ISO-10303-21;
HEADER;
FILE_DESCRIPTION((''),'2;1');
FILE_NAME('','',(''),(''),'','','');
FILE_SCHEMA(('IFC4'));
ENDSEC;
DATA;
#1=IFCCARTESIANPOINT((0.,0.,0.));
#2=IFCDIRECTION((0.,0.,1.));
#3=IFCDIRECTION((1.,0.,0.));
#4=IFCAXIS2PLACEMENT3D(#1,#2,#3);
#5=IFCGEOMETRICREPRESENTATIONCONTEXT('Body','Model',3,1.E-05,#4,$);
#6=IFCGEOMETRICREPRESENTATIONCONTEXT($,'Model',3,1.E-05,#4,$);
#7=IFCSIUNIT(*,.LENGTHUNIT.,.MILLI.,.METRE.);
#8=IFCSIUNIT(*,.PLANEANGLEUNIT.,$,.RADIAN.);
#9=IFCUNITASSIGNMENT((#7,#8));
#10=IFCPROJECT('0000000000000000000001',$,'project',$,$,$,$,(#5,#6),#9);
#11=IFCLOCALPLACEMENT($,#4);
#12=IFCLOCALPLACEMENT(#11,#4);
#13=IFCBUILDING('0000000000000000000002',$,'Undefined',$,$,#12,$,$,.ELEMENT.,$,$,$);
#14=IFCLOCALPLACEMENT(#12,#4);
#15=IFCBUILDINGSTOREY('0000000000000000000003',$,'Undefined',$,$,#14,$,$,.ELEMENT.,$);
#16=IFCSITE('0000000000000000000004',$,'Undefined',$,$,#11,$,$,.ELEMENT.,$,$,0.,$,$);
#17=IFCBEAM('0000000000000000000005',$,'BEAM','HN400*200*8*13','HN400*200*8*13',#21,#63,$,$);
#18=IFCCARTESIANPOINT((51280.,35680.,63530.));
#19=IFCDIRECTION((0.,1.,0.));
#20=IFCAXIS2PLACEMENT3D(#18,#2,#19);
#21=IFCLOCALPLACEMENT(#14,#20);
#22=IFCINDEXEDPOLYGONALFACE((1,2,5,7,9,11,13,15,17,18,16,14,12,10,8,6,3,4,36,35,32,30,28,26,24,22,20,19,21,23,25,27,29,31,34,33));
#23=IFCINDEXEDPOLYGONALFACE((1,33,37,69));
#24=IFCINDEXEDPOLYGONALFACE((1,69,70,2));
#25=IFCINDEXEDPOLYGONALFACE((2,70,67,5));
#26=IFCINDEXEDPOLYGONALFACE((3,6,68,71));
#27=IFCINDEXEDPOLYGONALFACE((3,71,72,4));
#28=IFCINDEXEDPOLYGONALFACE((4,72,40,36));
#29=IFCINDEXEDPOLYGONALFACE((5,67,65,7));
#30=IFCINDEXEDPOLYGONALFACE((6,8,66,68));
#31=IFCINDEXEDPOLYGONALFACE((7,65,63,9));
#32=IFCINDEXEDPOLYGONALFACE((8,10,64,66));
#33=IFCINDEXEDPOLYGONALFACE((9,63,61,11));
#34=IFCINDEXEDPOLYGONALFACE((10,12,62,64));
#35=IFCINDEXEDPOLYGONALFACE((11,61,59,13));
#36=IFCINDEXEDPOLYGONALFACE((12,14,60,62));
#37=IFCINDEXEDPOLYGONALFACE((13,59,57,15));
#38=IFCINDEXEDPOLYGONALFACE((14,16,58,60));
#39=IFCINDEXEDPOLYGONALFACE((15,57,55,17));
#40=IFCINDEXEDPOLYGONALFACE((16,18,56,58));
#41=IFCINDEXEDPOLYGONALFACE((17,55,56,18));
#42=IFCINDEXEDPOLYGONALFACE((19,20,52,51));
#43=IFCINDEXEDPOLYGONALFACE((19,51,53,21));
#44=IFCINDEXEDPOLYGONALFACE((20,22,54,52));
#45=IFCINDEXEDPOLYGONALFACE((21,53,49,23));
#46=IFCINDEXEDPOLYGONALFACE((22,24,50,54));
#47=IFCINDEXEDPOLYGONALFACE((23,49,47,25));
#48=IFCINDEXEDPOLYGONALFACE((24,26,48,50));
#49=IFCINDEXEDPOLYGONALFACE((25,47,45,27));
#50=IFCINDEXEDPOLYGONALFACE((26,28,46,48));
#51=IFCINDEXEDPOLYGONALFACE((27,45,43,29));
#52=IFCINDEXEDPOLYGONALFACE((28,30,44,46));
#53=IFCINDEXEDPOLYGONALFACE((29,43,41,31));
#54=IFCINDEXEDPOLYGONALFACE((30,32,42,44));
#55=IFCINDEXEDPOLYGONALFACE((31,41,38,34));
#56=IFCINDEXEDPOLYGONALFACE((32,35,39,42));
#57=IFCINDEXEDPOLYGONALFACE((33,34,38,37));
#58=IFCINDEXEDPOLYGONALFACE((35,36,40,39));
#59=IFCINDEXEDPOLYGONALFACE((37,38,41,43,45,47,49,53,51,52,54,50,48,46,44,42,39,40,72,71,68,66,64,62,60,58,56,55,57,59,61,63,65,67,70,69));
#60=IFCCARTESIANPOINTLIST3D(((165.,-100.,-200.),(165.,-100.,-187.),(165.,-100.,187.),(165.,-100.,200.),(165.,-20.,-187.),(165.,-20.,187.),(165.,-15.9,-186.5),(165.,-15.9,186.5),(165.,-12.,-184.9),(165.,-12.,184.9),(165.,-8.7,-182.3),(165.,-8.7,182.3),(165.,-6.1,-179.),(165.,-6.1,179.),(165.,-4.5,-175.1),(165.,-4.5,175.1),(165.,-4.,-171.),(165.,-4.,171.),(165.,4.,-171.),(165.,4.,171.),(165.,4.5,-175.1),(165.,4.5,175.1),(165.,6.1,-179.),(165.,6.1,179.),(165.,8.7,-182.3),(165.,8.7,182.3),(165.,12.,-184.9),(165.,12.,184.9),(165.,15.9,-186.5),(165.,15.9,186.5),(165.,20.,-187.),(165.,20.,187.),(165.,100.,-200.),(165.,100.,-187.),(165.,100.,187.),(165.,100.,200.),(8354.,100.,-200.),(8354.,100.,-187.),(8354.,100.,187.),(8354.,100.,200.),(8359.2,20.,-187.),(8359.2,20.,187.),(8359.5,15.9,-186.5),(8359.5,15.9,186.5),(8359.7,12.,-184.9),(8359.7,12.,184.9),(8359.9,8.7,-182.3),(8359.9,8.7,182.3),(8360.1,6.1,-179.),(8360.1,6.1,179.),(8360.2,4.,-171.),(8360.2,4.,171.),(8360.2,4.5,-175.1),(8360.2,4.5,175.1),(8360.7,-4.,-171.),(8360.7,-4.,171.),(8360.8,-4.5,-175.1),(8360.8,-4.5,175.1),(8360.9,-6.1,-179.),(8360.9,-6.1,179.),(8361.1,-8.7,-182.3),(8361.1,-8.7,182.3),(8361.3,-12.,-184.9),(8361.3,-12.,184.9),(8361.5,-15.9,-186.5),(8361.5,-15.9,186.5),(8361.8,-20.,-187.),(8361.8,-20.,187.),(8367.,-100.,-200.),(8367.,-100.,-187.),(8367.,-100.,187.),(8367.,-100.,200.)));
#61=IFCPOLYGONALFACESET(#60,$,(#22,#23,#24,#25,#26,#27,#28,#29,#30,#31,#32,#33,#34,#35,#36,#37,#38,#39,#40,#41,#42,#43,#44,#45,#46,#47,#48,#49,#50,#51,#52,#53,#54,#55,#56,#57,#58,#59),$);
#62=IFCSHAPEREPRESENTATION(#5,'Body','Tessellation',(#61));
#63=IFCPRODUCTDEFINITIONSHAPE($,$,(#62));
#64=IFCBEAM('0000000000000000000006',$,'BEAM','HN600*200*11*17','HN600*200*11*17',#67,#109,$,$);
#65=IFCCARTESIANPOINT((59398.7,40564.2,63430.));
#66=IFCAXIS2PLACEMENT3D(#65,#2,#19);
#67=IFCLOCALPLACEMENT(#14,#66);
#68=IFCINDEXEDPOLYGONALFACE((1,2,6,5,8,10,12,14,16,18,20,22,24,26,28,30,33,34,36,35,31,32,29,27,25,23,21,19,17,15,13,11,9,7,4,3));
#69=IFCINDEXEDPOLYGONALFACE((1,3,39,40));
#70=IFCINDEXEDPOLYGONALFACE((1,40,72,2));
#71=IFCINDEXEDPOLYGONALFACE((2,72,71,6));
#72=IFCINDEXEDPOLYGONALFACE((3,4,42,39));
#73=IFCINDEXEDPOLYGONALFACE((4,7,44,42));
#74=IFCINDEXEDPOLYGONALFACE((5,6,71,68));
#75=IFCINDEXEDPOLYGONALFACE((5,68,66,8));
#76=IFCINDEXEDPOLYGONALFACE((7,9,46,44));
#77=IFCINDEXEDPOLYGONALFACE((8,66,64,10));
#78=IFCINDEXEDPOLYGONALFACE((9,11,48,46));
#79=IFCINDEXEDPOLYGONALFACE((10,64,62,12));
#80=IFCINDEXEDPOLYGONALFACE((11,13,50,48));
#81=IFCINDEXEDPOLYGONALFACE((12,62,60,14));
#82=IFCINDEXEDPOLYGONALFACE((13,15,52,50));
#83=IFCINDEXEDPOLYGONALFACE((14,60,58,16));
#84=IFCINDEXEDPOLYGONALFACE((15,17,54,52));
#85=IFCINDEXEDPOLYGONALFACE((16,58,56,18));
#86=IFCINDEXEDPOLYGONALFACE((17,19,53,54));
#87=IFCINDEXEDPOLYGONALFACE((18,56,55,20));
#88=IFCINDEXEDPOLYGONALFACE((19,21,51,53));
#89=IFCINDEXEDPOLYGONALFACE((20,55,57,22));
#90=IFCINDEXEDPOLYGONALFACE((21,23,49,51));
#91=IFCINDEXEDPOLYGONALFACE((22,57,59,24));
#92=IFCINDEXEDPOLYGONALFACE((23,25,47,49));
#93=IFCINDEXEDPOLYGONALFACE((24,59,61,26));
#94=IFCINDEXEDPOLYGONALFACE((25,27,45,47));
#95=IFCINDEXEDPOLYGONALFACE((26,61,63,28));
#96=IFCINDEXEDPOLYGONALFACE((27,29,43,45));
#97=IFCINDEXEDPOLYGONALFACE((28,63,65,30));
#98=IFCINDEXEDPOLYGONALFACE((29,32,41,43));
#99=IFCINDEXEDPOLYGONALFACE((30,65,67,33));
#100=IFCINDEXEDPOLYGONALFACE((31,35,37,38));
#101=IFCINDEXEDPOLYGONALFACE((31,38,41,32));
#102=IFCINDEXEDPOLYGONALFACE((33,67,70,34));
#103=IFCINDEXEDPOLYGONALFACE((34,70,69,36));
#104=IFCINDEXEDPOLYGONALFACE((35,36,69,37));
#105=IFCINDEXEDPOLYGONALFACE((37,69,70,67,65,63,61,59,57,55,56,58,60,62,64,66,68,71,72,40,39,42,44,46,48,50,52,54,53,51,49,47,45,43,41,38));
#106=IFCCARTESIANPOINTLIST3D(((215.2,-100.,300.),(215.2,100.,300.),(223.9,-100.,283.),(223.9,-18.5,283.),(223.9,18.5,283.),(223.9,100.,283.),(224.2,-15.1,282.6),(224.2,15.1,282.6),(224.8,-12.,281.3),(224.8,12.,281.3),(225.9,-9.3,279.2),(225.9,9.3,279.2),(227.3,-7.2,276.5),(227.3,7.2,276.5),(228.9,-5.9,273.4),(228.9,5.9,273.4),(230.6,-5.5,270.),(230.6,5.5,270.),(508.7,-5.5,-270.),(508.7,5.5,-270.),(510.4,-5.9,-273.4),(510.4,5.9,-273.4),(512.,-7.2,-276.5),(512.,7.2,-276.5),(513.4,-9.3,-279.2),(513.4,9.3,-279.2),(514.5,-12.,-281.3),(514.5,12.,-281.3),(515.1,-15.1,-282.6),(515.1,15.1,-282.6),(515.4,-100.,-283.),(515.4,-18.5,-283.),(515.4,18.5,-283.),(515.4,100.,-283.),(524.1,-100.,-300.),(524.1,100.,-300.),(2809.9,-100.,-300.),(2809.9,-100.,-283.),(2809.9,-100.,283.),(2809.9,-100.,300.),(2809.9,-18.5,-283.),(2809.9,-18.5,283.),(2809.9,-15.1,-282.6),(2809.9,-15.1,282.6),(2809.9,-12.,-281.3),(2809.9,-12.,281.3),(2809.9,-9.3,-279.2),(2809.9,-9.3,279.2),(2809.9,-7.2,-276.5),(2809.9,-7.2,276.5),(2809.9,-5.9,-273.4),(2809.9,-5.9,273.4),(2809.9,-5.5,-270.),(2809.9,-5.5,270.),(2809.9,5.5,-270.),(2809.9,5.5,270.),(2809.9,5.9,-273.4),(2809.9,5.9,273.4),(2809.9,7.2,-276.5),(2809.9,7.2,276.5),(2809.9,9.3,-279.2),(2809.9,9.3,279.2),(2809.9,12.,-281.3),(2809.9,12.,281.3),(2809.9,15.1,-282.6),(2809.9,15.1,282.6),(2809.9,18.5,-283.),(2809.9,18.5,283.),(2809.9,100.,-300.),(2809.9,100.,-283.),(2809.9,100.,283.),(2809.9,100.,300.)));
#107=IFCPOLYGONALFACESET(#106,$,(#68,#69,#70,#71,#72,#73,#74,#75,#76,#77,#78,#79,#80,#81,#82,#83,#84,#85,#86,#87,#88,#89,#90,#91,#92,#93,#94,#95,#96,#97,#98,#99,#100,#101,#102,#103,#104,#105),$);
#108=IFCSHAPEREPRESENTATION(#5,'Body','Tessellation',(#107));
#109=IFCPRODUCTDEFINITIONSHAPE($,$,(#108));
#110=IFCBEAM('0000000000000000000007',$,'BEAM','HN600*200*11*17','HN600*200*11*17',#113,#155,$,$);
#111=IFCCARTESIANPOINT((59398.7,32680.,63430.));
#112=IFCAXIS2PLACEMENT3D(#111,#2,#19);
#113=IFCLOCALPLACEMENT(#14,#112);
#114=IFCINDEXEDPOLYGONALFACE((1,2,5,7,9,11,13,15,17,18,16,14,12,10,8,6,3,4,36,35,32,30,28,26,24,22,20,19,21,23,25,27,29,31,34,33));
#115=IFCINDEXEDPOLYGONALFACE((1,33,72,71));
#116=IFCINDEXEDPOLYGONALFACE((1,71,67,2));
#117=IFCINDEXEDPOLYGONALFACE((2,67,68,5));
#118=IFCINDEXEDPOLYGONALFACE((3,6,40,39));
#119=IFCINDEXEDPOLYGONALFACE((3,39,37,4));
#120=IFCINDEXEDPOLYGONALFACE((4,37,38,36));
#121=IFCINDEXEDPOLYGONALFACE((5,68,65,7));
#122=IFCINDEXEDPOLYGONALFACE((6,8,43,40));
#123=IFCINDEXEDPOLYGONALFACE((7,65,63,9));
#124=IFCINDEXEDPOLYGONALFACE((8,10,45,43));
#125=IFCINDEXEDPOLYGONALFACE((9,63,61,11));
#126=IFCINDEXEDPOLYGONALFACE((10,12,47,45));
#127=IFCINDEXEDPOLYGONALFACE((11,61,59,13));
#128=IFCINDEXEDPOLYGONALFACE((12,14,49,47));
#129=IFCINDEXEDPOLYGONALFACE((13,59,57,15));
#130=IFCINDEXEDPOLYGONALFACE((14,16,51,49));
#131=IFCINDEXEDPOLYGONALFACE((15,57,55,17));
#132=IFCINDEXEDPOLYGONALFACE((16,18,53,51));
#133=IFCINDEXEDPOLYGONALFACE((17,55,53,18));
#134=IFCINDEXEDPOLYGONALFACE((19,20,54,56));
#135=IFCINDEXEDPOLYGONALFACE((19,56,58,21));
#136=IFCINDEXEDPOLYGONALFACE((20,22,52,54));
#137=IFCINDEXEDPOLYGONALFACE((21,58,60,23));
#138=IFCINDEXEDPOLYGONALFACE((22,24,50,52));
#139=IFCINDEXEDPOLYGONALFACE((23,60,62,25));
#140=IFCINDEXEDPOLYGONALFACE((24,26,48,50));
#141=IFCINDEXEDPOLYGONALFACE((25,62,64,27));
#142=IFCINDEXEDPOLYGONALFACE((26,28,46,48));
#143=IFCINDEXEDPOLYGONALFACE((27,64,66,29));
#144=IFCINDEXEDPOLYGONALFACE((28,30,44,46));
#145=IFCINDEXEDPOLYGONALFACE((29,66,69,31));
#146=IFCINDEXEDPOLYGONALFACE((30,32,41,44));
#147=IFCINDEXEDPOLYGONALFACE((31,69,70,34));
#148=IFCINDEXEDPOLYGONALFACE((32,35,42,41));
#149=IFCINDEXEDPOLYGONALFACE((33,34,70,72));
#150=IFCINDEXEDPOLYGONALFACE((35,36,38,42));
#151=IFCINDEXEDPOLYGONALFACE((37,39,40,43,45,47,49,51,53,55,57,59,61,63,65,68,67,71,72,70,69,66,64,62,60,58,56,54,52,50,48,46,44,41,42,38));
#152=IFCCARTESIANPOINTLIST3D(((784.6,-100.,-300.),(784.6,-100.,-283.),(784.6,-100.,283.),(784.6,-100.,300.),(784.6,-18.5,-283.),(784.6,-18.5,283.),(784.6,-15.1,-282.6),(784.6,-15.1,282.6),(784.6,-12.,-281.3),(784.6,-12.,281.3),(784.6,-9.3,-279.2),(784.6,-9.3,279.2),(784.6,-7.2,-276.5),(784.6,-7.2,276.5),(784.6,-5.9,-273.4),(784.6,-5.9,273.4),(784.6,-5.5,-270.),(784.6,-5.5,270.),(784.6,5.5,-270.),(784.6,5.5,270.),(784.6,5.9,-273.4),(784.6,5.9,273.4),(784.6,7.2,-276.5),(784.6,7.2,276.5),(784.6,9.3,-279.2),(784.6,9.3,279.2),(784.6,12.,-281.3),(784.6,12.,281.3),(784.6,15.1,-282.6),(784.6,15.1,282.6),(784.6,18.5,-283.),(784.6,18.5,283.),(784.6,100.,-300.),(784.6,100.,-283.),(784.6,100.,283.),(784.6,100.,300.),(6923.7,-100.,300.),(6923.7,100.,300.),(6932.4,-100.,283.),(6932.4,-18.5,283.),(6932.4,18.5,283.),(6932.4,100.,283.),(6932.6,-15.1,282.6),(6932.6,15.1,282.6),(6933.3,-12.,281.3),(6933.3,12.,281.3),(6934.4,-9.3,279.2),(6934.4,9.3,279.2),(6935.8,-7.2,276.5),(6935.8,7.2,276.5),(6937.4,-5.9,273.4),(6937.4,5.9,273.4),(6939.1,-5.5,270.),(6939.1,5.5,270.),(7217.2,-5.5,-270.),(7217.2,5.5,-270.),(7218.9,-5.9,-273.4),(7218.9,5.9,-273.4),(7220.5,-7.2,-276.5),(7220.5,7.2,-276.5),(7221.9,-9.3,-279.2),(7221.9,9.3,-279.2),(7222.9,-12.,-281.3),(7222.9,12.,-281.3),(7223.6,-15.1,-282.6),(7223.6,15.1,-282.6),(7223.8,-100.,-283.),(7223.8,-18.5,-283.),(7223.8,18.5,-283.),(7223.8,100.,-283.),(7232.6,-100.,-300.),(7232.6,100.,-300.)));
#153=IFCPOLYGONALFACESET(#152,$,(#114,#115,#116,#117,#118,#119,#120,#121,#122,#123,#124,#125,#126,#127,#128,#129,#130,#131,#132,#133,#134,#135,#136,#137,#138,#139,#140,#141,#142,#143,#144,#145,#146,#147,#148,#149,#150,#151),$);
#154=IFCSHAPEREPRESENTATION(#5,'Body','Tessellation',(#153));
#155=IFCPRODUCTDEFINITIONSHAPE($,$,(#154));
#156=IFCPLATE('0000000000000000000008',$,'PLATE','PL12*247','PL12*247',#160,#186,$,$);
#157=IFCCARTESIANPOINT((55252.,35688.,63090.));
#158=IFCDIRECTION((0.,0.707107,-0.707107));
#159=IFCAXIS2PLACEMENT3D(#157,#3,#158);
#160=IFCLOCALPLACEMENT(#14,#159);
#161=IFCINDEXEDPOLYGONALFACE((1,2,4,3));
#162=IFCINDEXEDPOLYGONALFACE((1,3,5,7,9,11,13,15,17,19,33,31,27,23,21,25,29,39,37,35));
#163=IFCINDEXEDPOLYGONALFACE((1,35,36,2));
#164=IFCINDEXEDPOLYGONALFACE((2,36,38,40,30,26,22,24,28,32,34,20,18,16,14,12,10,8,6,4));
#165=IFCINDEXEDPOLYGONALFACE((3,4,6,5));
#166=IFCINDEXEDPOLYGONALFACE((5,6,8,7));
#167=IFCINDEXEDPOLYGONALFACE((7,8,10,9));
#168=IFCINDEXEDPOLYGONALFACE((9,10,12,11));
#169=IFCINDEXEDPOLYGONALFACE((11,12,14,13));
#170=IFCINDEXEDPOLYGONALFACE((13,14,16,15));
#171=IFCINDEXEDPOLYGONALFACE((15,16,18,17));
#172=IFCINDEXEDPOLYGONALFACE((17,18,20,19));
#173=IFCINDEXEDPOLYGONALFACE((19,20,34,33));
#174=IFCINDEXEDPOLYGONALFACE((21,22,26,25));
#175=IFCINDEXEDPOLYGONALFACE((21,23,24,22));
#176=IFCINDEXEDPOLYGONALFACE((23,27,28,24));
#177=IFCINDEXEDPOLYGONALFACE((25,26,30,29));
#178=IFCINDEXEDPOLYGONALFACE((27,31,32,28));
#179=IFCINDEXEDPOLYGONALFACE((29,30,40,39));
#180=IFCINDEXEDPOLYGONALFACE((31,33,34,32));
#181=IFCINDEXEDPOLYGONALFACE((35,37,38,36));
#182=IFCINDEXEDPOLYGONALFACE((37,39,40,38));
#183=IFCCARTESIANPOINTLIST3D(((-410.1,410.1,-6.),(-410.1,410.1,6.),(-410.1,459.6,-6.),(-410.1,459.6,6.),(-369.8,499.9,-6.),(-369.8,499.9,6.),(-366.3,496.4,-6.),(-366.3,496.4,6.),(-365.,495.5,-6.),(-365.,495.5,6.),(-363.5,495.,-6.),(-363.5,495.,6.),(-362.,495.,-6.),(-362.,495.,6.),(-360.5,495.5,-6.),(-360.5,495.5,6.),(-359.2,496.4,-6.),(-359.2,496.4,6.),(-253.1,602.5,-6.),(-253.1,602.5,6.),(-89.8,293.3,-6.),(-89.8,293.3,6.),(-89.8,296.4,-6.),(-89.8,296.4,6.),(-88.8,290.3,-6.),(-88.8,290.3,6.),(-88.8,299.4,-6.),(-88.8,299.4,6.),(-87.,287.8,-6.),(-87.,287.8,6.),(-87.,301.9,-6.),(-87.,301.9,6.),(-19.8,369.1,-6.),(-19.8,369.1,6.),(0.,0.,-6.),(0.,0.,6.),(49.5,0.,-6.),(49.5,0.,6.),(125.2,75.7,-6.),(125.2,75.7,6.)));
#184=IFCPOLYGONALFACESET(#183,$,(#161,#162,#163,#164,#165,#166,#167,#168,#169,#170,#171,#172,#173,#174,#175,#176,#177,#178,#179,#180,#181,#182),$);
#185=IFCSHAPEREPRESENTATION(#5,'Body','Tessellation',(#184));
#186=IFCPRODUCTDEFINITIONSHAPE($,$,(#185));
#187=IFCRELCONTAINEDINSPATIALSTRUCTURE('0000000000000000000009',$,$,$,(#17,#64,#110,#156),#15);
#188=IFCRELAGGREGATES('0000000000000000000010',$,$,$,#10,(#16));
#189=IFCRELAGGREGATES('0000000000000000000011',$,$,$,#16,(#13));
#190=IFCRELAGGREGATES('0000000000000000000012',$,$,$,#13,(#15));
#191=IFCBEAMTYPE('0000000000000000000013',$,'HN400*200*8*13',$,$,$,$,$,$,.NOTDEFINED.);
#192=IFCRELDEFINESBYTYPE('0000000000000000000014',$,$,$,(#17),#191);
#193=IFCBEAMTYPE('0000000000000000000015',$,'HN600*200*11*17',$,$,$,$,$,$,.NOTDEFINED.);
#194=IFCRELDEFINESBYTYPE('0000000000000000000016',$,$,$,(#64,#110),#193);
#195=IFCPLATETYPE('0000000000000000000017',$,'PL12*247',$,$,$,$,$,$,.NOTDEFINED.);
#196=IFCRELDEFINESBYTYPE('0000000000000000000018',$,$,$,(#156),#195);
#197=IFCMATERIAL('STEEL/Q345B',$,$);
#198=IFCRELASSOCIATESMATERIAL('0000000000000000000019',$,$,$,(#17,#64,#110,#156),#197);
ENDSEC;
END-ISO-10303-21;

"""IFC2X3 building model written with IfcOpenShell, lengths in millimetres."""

from ifc_helpers import new_model, si_unit, frame, origin_with_axes, origin_2d_with_axis, place, context, project, spatial, polyline, i_section, outline, extrude, clip, halfspace, material, type_object, element, save


model = new_model("IFC2X3")

# Units and contexts
model_context_1 = context("Model", 3, precision=1e-05, world=origin_with_axes(), identifier="Body")
model_context_2 = context("Model", 3, precision=1e-05, world=origin_with_axes())
ifc_project = project(units=[si_unit("LENGTHUNIT", "METRE", prefix="MILLI"), si_unit("PLANEANGLEUNIT", "RADIAN")], contexts=[model_context_1, model_context_2])

# Site, building, storey
site_placement = place(None, origin_with_axes())
site = spatial("IfcSite", under=ifc_project, at=site_placement, Name="Undefined", CompositionType="ELEMENT", RefElevation=0.0)
building_placement = place(site_placement, origin_with_axes())
building = spatial("IfcBuilding", under=site, at=building_placement, Name="Undefined", CompositionType="ELEMENT")
storey_placement = place(building_placement, origin_with_axes())
storey = spatial("IfcBuildingStorey", under=building, at=storey_placement, Name="Undefined", CompositionType="ELEMENT")

# Beams
ifc_material_1 = material(Name="STEEL/Q345B")
beam_type_1 = type_object("IfcBeamType", Name="HN400*200*8*13", PredefinedType="NOTDEFINED")
beam_1_placement = place(storey_placement, frame((51280.0, 35680.0, 63530.0), z_axis=(0.0, 0.0, 1.0), x_axis=(0.0, 1.0, 0.0)))
element("IfcBeam", 1, at=beam_1_placement, inside=storey, type_object=beam_type_1, material=ifc_material_1, Name="BEAM", Description="HN400*200*8*13", ObjectType="HN400*200*8*13", context=model_context_1, shape_type="Clipping", body=[
    clip(clip(extrude(i_section(OverallWidth=200.0, OverallDepth=400.0, WebThickness=8.0, FlangeThickness=13.0, FilletRadius=16.0, at=origin_2d_with_axis()), frame((8367.1, 0.0, 0.0), z_axis=(-1.0, 0.0, 0.0), x_axis=(0.0, -1.0, 0.0)), (0.0, 0.0, 1.0), 8202.1), halfspace(frame((165.0, 58.0, 200.0), z_axis=(1.0, 0.0, 0.0), x_axis=(0.0, -1.0, 0.0)), True)), halfspace(frame((8361.3, -13.2, 300.0), z_axis=(0.997873, 0.065184, 0.0), x_axis=(0.0, 0.0, -1.0)), False)),
])
beam_type_2 = type_object("IfcBeamType", Name="HN600*200*11*17", PredefinedType="NOTDEFINED")
beam_2_placement = place(storey_placement, frame((59398.7, 40564.2, 63430.0), z_axis=(0.0, 0.0, 1.0), x_axis=(0.0, 1.0, 0.0)))
element("IfcBeam", 2, at=beam_2_placement, inside=storey, type_object=beam_type_2, material=ifc_material_1, Name="BEAM", Description="HN600*200*11*17", ObjectType="HN600*200*11*17", context=model_context_1, shape_type="Clipping", body=[
    clip(clip(extrude(i_section(OverallWidth=200.0, OverallDepth=600.0, WebThickness=11.0, FlangeThickness=17.0, FilletRadius=13.0, at=origin_2d_with_axis()), frame((2809.9, 0.0, 0.0), z_axis=(-1.0, 0.0, 0.0), x_axis=(0.0, -1.0, 0.0)), (0.0, 0.0, 1.0), 2596.3), halfspace(frame((223.9, 0.0, 283.0), z_axis=(-0.88907, 0.0, -0.457771), x_axis=(0.457771, 0.0, -0.88907)), False)), halfspace(frame((2809.9, 0.0, -71.8), z_axis=(1.0, 0.0, 0.0), x_axis=(0.0, -1.0, 0.0)), False)),
])
beam_3_placement = place(storey_placement, frame((59398.7, 32680.0, 63430.0), z_axis=(0.0, 0.0, 1.0), x_axis=(0.0, 1.0, 0.0)))
element("IfcBeam", 3, at=beam_3_placement, inside=storey, type_object=beam_type_2, material=ifc_material_1, Name="BEAM", Description="HN600*200*11*17", ObjectType="HN600*200*11*17", context=model_context_1, shape_type="Clipping", body=[
    clip(clip(extrude(i_section(OverallWidth=200.0, OverallDepth=600.0, WebThickness=11.0, FlangeThickness=17.0, FilletRadius=13.0, at=origin_2d_with_axis()), frame((7234.1, 0.0, 0.0), z_axis=(-1.0, 0.0, 0.0), x_axis=(0.0, -1.0, 0.0)), (0.0, 0.0, 1.0), 6449.5), halfspace(frame((6923.7, 0.0, 300.0), z_axis=(-0.88907, 0.0, -0.457771), x_axis=(0.457771, 0.0, -0.88907)), True)), halfspace(frame((784.6, 0.0, 1000.0), z_axis=(-1.0, 0.0, 0.0), x_axis=(0.0, -1.0, 0.0)), False)),
])

# Plate
plate_type_1 = type_object("IfcPlateType", Name="PL12*247", PredefinedType="NOTDEFINED")
for number, where, z_axis, x_axis, name in (
    (4, (55252.0, 35688.0, 63090.0), (1.0, 0.0, 0.0), (0.0, 0.707107, -0.707107), "PLATE"),
):
    element("IfcPlate", number, at=place(storey_placement, frame(where, z_axis=z_axis, x_axis=x_axis)), inside=storey, type_object=plate_type_1, material=ifc_material_1, Name=name, Description="PL12*247", ObjectType="PL12*247", context=model_context_1, shape_type="SweptSolid", body=[
        extrude(outline(polyline([(0.0, 0.0), (49.5, 0.0), (125.2, 75.7), (-87.0, 287.8), (-88.8, 290.3), (-89.8, 293.3), (-89.8, 296.4), (-88.8, 299.4), (-87.0, 301.9), (-19.8, 369.1), (-253.1, 602.5), (-359.2, 496.4), (-360.5, 495.5), (-362.0, 495.0), (-363.5, 495.0), (-365.0, 495.5), (-366.3, 496.4), (-369.8, 499.9), (-410.1, 459.6), (-410.1, 410.1), (0.0, 0.0)])), frame((0.0, 0.0, -6.0), z_axis=(0.0, 0.0, 1.0), x_axis=(1.0, 0.0, 0.0)), (0.0, 0.0, 1.0), 12.0),
    ])

save(model, "model.ifc")
